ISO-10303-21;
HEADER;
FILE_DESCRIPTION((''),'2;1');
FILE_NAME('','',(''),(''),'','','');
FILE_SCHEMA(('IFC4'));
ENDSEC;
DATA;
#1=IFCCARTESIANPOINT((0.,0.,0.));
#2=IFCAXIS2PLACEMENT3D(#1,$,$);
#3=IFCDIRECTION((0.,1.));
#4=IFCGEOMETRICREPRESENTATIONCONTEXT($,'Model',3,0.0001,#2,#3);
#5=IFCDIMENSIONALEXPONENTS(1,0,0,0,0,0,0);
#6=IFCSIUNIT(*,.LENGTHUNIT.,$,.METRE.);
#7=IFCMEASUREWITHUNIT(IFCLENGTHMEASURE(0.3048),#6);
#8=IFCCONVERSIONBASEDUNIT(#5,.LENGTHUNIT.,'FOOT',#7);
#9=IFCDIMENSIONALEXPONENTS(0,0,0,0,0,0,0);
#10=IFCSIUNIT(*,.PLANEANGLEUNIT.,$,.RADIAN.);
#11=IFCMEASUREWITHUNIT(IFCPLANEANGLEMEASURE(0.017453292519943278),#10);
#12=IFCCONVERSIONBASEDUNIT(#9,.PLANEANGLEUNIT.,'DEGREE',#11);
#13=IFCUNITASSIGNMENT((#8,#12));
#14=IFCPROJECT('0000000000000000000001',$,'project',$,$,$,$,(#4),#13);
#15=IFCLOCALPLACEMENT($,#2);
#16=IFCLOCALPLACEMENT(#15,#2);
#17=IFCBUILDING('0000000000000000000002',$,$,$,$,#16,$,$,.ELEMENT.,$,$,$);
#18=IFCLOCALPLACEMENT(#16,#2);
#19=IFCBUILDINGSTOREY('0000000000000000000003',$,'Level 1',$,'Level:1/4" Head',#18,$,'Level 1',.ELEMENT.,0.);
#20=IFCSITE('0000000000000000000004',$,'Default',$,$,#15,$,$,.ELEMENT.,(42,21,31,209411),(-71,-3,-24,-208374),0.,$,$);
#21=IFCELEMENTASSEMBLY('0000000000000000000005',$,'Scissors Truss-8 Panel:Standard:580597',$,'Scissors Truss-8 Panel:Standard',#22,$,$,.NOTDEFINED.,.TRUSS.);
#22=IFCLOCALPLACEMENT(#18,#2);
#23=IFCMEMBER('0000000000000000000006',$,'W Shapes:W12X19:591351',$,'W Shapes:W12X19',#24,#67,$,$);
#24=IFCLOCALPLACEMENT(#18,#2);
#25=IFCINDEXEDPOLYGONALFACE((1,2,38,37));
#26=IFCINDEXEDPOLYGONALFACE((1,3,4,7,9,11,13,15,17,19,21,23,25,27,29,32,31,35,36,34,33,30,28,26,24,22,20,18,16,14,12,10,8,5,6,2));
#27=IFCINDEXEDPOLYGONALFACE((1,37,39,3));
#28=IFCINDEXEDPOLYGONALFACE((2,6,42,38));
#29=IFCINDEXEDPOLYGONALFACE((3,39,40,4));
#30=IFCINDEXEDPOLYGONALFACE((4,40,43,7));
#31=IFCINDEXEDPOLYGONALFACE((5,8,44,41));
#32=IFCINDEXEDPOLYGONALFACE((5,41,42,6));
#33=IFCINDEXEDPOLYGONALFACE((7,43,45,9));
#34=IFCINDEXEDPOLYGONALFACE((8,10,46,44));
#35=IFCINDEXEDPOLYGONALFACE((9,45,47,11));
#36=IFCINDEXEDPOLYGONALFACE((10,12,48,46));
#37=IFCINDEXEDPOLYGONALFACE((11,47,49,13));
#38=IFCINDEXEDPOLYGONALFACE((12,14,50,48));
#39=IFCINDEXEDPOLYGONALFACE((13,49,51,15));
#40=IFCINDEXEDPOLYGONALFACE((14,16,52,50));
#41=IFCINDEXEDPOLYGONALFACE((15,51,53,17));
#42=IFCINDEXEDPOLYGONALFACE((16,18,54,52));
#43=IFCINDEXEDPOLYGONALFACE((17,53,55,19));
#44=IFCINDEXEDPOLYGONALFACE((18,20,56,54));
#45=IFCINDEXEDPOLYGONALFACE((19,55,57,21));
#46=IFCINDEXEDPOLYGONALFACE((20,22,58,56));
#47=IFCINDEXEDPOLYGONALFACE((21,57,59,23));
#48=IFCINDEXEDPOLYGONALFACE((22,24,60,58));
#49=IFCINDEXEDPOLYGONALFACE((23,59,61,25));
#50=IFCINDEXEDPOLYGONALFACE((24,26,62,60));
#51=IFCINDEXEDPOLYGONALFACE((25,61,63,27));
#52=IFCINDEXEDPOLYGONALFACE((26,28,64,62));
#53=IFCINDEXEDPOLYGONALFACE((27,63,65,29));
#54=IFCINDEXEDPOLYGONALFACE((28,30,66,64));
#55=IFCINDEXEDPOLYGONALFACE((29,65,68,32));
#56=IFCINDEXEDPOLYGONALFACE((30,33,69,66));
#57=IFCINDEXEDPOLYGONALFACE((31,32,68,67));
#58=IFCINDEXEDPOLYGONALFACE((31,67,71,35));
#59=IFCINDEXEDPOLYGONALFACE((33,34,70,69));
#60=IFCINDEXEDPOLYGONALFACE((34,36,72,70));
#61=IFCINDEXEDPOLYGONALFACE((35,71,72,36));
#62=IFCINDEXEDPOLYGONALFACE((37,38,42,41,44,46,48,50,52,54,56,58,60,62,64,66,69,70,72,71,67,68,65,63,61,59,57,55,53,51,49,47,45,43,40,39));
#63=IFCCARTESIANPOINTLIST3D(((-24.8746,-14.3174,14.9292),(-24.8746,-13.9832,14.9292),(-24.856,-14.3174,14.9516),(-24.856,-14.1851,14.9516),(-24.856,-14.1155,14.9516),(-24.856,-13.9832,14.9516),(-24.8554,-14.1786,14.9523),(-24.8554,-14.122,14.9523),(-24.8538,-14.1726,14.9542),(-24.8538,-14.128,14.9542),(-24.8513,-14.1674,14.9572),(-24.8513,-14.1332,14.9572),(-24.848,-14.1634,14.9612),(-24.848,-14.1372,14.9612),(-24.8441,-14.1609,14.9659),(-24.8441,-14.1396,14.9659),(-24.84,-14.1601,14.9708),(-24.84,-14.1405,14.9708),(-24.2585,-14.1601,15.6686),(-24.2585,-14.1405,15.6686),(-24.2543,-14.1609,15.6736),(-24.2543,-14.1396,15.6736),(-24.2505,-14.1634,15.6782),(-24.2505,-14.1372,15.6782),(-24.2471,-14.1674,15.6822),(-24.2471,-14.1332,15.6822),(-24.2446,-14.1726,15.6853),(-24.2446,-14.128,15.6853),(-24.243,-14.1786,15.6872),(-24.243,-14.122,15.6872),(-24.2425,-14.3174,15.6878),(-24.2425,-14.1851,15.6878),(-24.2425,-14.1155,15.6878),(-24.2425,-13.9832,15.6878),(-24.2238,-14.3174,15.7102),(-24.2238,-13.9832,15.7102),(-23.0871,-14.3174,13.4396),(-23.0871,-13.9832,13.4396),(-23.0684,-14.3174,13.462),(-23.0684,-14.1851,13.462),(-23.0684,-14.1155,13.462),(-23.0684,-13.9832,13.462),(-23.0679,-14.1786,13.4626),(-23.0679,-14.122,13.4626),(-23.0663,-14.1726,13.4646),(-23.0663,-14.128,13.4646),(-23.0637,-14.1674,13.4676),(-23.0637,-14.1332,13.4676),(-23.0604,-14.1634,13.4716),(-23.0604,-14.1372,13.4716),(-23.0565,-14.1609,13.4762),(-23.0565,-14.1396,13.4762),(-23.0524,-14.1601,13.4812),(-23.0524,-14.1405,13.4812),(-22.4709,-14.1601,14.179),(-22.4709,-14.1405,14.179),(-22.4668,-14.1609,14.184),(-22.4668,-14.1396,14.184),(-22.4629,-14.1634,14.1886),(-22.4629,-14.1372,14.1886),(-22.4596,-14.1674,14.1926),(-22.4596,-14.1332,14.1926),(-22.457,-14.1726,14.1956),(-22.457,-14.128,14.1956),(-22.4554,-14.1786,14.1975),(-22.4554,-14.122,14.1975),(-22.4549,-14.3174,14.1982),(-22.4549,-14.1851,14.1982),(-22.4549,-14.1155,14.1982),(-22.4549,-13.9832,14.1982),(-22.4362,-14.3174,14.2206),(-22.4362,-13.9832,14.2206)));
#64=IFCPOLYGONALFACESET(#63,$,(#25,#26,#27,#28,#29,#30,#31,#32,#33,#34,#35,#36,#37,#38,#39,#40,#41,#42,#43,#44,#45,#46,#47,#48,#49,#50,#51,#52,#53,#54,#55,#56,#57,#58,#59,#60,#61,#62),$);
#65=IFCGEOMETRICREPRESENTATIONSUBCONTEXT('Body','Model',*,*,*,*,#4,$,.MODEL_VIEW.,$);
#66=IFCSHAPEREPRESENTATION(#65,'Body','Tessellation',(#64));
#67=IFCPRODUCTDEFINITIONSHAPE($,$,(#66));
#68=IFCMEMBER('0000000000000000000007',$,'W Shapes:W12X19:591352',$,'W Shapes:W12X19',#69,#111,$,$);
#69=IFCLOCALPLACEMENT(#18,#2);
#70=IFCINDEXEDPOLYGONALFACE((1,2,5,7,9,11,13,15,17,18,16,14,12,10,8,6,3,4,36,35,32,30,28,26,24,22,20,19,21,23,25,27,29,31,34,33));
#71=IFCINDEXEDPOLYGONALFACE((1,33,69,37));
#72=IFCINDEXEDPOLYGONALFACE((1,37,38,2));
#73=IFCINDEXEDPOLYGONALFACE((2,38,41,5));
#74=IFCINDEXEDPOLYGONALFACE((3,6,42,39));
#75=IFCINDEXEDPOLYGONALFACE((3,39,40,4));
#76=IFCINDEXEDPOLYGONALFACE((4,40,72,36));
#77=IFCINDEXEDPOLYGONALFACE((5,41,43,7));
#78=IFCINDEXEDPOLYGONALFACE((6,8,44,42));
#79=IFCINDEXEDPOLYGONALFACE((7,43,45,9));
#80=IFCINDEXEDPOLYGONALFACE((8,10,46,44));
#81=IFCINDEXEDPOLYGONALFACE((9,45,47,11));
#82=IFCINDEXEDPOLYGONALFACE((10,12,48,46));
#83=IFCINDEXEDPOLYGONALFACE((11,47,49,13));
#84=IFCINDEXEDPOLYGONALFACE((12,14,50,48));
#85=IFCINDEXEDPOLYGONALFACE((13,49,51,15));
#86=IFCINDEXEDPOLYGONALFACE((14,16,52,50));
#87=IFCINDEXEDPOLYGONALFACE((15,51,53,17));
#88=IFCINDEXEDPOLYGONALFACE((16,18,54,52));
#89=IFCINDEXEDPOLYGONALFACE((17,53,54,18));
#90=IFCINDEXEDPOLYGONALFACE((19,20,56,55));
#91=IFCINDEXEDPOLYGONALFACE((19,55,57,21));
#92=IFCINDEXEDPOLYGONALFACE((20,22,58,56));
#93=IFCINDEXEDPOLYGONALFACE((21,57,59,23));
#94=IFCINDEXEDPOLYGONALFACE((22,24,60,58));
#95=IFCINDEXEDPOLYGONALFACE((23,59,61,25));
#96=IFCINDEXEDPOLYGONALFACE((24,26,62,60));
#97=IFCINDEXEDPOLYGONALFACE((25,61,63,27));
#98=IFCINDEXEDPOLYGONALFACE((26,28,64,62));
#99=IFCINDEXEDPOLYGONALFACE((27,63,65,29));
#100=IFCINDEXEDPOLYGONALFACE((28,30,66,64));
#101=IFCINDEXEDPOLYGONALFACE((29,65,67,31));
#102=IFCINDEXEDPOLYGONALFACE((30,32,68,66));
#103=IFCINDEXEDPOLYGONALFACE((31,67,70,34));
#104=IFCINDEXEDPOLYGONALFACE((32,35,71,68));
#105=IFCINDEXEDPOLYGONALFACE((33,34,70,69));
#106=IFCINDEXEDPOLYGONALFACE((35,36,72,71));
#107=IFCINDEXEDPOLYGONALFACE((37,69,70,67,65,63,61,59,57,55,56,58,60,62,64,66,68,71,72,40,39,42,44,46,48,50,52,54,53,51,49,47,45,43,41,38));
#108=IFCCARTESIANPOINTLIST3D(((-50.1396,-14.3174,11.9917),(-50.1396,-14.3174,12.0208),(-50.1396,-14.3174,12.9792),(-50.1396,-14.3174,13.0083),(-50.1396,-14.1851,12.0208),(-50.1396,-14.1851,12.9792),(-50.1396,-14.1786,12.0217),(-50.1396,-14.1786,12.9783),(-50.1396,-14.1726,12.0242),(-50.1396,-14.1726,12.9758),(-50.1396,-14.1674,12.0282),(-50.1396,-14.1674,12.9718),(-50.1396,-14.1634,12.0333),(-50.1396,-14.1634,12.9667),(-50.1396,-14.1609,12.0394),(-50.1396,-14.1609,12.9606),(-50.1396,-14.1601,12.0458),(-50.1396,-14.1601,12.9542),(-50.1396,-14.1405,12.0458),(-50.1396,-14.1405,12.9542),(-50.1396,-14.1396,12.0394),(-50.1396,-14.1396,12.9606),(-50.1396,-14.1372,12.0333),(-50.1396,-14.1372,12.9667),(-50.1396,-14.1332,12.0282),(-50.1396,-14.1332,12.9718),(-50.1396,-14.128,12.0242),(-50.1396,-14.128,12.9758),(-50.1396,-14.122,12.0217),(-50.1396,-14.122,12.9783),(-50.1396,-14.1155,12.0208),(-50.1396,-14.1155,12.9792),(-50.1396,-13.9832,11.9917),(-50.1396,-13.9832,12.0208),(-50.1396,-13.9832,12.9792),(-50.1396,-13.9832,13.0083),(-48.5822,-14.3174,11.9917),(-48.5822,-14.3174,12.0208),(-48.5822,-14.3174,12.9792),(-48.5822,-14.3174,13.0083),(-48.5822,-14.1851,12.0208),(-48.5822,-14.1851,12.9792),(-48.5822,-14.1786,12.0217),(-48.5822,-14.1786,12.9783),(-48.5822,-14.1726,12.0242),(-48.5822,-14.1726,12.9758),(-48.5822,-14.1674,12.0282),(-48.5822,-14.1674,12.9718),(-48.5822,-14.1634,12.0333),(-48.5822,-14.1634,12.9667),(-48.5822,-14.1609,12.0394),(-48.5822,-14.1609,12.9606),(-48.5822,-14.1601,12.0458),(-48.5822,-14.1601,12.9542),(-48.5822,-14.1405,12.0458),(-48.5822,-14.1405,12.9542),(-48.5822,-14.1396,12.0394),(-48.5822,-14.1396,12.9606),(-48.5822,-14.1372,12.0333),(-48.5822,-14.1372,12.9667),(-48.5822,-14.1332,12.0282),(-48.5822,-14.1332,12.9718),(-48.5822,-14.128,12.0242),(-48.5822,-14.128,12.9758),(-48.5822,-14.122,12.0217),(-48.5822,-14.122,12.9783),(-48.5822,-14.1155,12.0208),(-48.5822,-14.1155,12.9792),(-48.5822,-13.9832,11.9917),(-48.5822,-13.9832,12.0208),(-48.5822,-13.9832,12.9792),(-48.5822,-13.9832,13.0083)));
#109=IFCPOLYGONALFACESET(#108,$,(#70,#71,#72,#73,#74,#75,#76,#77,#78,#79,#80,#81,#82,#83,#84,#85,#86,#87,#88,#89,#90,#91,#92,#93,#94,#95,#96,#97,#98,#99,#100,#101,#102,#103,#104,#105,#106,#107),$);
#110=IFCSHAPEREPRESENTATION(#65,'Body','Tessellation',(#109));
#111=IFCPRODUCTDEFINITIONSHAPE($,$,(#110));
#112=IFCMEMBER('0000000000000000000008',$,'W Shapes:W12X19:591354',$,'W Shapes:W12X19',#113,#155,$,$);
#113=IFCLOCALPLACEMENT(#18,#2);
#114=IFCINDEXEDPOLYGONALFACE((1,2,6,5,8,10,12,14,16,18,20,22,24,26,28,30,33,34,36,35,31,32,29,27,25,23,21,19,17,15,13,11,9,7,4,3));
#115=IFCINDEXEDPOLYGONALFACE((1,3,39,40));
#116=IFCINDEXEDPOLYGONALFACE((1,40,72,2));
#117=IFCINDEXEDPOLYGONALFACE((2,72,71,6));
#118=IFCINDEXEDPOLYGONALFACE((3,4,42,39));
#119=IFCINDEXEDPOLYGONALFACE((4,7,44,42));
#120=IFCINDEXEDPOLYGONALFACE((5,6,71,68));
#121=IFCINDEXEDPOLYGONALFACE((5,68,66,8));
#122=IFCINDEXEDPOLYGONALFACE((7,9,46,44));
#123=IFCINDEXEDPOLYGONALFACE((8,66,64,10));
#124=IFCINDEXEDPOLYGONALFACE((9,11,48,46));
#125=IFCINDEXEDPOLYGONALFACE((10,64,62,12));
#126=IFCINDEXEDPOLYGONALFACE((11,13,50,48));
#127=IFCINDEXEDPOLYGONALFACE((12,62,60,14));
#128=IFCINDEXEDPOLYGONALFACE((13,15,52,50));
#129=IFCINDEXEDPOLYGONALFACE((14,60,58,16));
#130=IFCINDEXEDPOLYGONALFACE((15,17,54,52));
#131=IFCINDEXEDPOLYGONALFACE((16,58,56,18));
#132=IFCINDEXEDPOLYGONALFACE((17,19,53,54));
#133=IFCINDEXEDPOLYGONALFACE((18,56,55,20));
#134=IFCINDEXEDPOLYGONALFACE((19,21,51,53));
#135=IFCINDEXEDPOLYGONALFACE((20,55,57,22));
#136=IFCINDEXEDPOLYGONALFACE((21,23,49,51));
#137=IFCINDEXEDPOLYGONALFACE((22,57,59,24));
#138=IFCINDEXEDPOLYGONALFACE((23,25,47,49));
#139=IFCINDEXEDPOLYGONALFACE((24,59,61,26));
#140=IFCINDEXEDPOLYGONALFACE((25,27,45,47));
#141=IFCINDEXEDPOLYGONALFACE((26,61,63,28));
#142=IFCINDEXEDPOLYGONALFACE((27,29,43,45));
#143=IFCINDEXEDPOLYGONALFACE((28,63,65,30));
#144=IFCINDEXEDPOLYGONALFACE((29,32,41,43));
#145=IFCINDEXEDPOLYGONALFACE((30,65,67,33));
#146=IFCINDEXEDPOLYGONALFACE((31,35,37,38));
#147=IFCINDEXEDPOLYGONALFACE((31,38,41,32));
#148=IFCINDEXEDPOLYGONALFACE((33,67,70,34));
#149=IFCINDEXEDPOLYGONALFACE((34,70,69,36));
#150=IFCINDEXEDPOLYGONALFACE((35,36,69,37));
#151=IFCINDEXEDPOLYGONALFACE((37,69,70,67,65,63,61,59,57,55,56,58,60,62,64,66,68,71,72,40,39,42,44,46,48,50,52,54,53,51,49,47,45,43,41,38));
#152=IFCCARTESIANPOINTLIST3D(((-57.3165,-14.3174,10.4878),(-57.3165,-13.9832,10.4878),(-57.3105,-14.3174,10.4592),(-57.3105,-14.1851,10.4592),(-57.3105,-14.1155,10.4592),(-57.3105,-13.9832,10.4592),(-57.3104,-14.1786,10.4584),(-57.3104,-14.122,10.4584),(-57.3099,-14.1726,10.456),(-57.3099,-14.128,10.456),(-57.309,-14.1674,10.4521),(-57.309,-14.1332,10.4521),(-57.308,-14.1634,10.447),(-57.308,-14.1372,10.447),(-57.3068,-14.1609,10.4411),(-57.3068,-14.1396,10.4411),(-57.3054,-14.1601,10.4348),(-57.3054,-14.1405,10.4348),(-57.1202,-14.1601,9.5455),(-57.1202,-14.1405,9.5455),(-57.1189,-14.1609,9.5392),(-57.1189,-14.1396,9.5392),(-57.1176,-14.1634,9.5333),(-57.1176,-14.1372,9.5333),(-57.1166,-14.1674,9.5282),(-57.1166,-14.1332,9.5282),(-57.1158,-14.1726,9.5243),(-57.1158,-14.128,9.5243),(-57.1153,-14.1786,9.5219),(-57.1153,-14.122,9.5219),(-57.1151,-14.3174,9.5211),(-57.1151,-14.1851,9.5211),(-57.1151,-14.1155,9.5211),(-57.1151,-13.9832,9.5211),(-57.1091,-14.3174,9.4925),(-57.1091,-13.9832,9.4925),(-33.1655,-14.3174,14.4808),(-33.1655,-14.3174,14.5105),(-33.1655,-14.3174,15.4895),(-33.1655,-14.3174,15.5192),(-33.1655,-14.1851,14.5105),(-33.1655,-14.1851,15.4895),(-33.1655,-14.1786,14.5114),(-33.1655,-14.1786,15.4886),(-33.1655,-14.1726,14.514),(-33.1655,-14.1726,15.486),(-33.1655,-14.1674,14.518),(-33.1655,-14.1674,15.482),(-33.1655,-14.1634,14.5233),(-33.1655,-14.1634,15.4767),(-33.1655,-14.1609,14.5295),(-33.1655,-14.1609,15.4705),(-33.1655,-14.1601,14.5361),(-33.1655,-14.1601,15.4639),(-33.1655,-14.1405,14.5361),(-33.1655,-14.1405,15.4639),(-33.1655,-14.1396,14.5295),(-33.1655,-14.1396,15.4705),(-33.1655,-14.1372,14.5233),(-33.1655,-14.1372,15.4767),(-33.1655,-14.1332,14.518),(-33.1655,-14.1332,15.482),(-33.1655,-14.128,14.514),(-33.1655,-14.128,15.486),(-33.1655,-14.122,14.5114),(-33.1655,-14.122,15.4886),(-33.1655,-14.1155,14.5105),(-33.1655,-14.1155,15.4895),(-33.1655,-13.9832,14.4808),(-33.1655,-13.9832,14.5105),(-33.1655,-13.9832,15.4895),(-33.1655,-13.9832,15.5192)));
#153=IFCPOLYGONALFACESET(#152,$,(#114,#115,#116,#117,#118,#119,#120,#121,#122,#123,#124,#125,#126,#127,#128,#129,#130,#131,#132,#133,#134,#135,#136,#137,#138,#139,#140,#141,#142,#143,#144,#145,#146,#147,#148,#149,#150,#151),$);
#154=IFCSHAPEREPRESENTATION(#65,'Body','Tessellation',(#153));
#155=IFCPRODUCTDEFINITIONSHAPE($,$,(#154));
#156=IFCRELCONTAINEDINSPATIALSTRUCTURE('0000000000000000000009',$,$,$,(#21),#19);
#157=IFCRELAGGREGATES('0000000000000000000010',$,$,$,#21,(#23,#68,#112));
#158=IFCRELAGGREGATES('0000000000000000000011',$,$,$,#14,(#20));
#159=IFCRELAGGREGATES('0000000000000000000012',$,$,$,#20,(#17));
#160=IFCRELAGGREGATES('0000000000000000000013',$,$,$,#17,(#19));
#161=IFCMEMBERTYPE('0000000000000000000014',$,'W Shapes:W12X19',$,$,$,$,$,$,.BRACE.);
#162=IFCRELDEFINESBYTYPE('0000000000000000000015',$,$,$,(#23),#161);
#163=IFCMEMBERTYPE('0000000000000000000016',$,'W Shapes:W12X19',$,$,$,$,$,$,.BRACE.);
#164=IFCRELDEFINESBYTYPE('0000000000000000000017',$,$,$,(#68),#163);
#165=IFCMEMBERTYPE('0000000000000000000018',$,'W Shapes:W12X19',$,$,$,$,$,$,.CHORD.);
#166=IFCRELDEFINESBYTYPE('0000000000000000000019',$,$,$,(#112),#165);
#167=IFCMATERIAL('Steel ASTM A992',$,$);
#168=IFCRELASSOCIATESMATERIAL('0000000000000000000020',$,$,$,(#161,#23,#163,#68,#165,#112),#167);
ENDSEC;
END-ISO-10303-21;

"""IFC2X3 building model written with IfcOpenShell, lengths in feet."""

from ifc_helpers import new_model, entity, si_unit, converted_unit, direction, frame, frame_2d, origin, place, context, subcontext, project, spatial, polyline, circle_curve, parameter, trimmed, segment, composite_curve, i_section, outline, extrude, clip, halfspace, source, transform, mapped, material, type_object, type_shapes, element, aggregate, save


model = new_model("IFC2X3")

# Units and contexts
model_context = context("Model", 3, precision=0.0001, world=origin(), true_north=direction((0.0, 1.0)))
body_context = subcontext(model_context, "Body", "Model", "MODEL_VIEW")
ifc_project = project(units=[converted_unit("LENGTHUNIT", "FOOT", entity("IfcLengthMeasure", 0.3048), si_unit("LENGTHUNIT", "METRE"), dimensions=[1, 0, 0, 0, 0, 0, 0]), converted_unit("PLANEANGLEUNIT", "DEGREE", entity("IfcPlaneAngleMeasure", 0.017453292519943278), si_unit("PLANEANGLEUNIT", "RADIAN"), dimensions=[0, 0, 0, 0, 0, 0, 0])], contexts=[model_context])

# Site, building, storey
site_placement = place(None, origin())
site = spatial("IfcSite", under=ifc_project, at=site_placement, Name="Default", CompositionType="ELEMENT", RefLatitude=(42, 21, 31, 209411), RefLongitude=(-71, -3, -24, -208374), RefElevation=0.0)
building_placement = place(site_placement, origin())
building = spatial("IfcBuilding", under=site, at=building_placement, CompositionType="ELEMENT")
storey_placement = place(building_placement, origin())
storey = spatial("IfcBuildingStorey", under=building, at=storey_placement, Name="Level 1", ObjectType="Level:1/4\" Head", LongName="Level 1", CompositionType="ELEMENT", Elevation=0.0)

# Element assembly, members
assembly_placement = place(storey_placement, origin())
assembly = element("IfcElementAssembly", 1, at=assembly_placement, inside=storey, Name="Scissors Truss-8 Panel:Standard:580597", ObjectType="Scissors Truss-8 Panel:Standard", AssemblyPlace="NOTDEFINED", PredefinedType="TRUSS")
ifc_material = material(Name="Steel ASTM A992")
member_type_1 = type_object("IfcMemberType", Name="W Shapes:W12X19", PredefinedType="BRACE", material=ifc_material)
shared_shape_1 = source(origin(), body_context, "Body", "SweptSolid", [
    extrude(outline(composite_curve([segment(polyline([(-0.1671, -0.4792), (-0.1671, -0.5083)]), True, "CONTINUOUS"), segment(polyline([(-0.1671, -0.5083), (0.1671, -0.5083)]), True, "CONTINUOUS"), segment(polyline([(0.1671, -0.5083), (0.1671, -0.4792)]), True, "CONTINUOUS"), segment(polyline([(0.1671, -0.4792), (0.0348, -0.4792)]), True, "CONTINUOUS"), segment(trimmed(circle_curve(frame_2d((0.0348, -0.4542), x_axis=(1.0, 0.0)), 0.025), [parameter(180.0)], [parameter(270.0)], True, "PARAMETER"), False, "CONTINUOUS"), segment(polyline([(0.0098, -0.4542), (0.0098, 0.4542)]), True, "CONTINUOUS"), segment(trimmed(circle_curve(frame_2d((0.0348, 0.4542), x_axis=(1.0, 0.0)), 0.025), [parameter(90.0)], [parameter(180.0)], True, "PARAMETER"), False, "CONTINUOUS"), segment(polyline([(0.0348, 0.4792), (0.1671, 0.4792)]), True, "CONTINUOUS"), segment(polyline([(0.1671, 0.4792), (0.1671, 0.5083)]), True, "CONTINUOUS"), segment(polyline([(0.1671, 0.5083), (-0.1671, 0.5083)]), True, "CONTINUOUS"), segment(polyline([(-0.1671, 0.5083), (-0.1671, 0.4792)]), True, "CONTINUOUS"), segment(polyline([(-0.1671, 0.4792), (-0.0348, 0.4792)]), True, "CONTINUOUS"), segment(trimmed(circle_curve(frame_2d((-0.0348, 0.4542), x_axis=(1.0, 0.0)), 0.025), [parameter(360.0)], [parameter(90.0)], True, "PARAMETER"), False, "CONTINUOUS"), segment(polyline([(-0.0098, 0.4542), (-0.0098, -0.4542)]), True, "CONTINUOUS"), segment(trimmed(circle_curve(frame_2d((-0.0348, -0.4542), x_axis=(1.0, 0.0)), 0.025), [parameter(270.0)], [parameter(360.0)], True, "PARAMETER"), False, "CONTINUOUS"), segment(polyline([(-0.0348, -0.4792), (-0.1671, -0.4792)]), True, "CONTINUOUS")], self_intersect=False)), frame((-0.4994, 0.0, 0.0), z_axis=(-1.0, 0.0, 0.0), x_axis=(0.0, -1.0, 0.0)), (0.0, 0.0, -1.0), 2.3269),
])
type_shapes(member_type_1, [shared_shape_1])
member_1_placement = place(assembly_placement, frame((-24.1655, -14.1503, 15.0), z_axis=(-0.640184, 0.0, -0.768221), x_axis=(0.768221, 0.0, -0.640184)))
member_1 = element("IfcMember", 2, at=member_1_placement, type_object=member_type_1, material=ifc_material, Name="W Shapes:W12X19:591351", ObjectType="W Shapes:W12X19", context=body_context, shape_type="MappedRepresentation", body=[
    mapped(shared_shape_1, transform((0.0, 0.0, 0.0), scale=1.0)),
])
member_type_2 = type_object("IfcMemberType", Name="W Shapes:W12X19", PredefinedType="BRACE", material=ifc_material)
shared_shape_2 = source(origin(), body_context, "Body", "SweptSolid", [
    extrude(outline(composite_curve([segment(polyline([(0.4792, -0.1671), (0.5083, -0.1671)]), True, "CONTINUOUS"), segment(polyline([(0.5083, -0.1671), (0.5083, 0.1671)]), True, "CONTINUOUS"), segment(polyline([(0.5083, 0.1671), (0.4792, 0.1671)]), True, "CONTINUOUS"), segment(polyline([(0.4792, 0.1671), (0.4792, 0.0348)]), True, "CONTINUOUS"), segment(trimmed(circle_curve(frame_2d((0.4542, 0.0348), x_axis=(0.0, 1.0)), 0.025), [parameter(180.0)], [parameter(270.0)], True, "PARAMETER"), False, "CONTINUOUS"), segment(polyline([(0.4542, 0.0098), (-0.4542, 0.0098)]), True, "CONTINUOUS"), segment(trimmed(circle_curve(frame_2d((-0.4542, 0.0348), x_axis=(0.0, 1.0)), 0.025), [parameter(90.0)], [parameter(180.0)], True, "PARAMETER"), False, "CONTINUOUS"), segment(polyline([(-0.4792, 0.0348), (-0.4792, 0.1671)]), True, "CONTINUOUS"), segment(polyline([(-0.4792, 0.1671), (-0.5083, 0.1671)]), True, "CONTINUOUS"), segment(polyline([(-0.5083, 0.1671), (-0.5083, -0.1671)]), True, "CONTINUOUS"), segment(polyline([(-0.5083, -0.1671), (-0.4792, -0.1671)]), True, "CONTINUOUS"), segment(polyline([(-0.4792, -0.1671), (-0.4792, -0.0348)]), True, "CONTINUOUS"), segment(trimmed(circle_curve(frame_2d((-0.4542, -0.0348), x_axis=(0.0, 1.0)), 0.025), [parameter(360.0)], [parameter(90.0)], True, "PARAMETER"), False, "CONTINUOUS"), segment(polyline([(-0.4542, -0.0098), (0.4542, -0.0098)]), True, "CONTINUOUS"), segment(trimmed(circle_curve(frame_2d((0.4542, -0.0348), x_axis=(0.0, 1.0)), 0.025), [parameter(270.0)], [parameter(360.0)], True, "PARAMETER"), False, "CONTINUOUS"), segment(polyline([(0.4792, -0.0348), (0.4792, -0.1671)]), True, "CONTINUOUS")], self_intersect=False)), frame((-1.9741, 0.0, 0.0), z_axis=(1.0, 0.0, 0.0), x_axis=(0.0, 0.0, -1.0)), (0.0, 0.0, 1.0), 1.5574),
])
type_shapes(member_type_2, [shared_shape_2])
member_2_placement = place(assembly_placement, frame((-48.1655, -14.1503, 12.5), z_axis=(0.0, 0.0, -1.0), x_axis=(1.0, 0.0, 0.0)))
member_2 = element("IfcMember", 3, at=member_2_placement, type_object=member_type_2, material=ifc_material, Name="W Shapes:W12X19:591352", ObjectType="W Shapes:W12X19", context=body_context, shape_type="MappedRepresentation", body=[
    mapped(shared_shape_2, transform((0.0, 0.0, 0.0), scale=1.0)),
])
member_type_3 = type_object("IfcMemberType", Name="W Shapes:W12X19", PredefinedType="CHORD", material=ifc_material)
shared_shape_3 = source(origin(), body_context, "Body", "Clipping", [
    clip(extrude(i_section(OverallWidth=0.3342, OverallDepth=1.0167, WebThickness=0.0196, FlangeThickness=0.0292, FilletRadius=0.025, at=frame_2d((0.0, 0.0), x_axis=(1.0, 0.0))), frame((-57.2128, -14.1503, 9.9902), z_axis=(0.97898, 0.0, 0.203954), x_axis=(0.0, -1.0, 0.0)), (0.0, 0.0, 1.0), 24.6695), halfspace(frame((-33.1655, -14.1503, 15.5192), z_axis=(1.0, 0.0, 0.0), x_axis=(0.0, -1.0, 0.0)), False)),
])
type_shapes(member_type_3, [shared_shape_3])
member_3_placement = place(assembly_placement, origin())
member_3 = element("IfcMember", 4, at=member_3_placement, type_object=member_type_3, material=ifc_material, Name="W Shapes:W12X19:591354", ObjectType="W Shapes:W12X19", context=body_context, shape_type="MappedRepresentation", body=[
    mapped(shared_shape_3, transform((0.0, 0.0, 0.0), scale=1.0)),
])
aggregate(assembly, [member_1, member_2, member_3])

save(model, "model.ifc")
